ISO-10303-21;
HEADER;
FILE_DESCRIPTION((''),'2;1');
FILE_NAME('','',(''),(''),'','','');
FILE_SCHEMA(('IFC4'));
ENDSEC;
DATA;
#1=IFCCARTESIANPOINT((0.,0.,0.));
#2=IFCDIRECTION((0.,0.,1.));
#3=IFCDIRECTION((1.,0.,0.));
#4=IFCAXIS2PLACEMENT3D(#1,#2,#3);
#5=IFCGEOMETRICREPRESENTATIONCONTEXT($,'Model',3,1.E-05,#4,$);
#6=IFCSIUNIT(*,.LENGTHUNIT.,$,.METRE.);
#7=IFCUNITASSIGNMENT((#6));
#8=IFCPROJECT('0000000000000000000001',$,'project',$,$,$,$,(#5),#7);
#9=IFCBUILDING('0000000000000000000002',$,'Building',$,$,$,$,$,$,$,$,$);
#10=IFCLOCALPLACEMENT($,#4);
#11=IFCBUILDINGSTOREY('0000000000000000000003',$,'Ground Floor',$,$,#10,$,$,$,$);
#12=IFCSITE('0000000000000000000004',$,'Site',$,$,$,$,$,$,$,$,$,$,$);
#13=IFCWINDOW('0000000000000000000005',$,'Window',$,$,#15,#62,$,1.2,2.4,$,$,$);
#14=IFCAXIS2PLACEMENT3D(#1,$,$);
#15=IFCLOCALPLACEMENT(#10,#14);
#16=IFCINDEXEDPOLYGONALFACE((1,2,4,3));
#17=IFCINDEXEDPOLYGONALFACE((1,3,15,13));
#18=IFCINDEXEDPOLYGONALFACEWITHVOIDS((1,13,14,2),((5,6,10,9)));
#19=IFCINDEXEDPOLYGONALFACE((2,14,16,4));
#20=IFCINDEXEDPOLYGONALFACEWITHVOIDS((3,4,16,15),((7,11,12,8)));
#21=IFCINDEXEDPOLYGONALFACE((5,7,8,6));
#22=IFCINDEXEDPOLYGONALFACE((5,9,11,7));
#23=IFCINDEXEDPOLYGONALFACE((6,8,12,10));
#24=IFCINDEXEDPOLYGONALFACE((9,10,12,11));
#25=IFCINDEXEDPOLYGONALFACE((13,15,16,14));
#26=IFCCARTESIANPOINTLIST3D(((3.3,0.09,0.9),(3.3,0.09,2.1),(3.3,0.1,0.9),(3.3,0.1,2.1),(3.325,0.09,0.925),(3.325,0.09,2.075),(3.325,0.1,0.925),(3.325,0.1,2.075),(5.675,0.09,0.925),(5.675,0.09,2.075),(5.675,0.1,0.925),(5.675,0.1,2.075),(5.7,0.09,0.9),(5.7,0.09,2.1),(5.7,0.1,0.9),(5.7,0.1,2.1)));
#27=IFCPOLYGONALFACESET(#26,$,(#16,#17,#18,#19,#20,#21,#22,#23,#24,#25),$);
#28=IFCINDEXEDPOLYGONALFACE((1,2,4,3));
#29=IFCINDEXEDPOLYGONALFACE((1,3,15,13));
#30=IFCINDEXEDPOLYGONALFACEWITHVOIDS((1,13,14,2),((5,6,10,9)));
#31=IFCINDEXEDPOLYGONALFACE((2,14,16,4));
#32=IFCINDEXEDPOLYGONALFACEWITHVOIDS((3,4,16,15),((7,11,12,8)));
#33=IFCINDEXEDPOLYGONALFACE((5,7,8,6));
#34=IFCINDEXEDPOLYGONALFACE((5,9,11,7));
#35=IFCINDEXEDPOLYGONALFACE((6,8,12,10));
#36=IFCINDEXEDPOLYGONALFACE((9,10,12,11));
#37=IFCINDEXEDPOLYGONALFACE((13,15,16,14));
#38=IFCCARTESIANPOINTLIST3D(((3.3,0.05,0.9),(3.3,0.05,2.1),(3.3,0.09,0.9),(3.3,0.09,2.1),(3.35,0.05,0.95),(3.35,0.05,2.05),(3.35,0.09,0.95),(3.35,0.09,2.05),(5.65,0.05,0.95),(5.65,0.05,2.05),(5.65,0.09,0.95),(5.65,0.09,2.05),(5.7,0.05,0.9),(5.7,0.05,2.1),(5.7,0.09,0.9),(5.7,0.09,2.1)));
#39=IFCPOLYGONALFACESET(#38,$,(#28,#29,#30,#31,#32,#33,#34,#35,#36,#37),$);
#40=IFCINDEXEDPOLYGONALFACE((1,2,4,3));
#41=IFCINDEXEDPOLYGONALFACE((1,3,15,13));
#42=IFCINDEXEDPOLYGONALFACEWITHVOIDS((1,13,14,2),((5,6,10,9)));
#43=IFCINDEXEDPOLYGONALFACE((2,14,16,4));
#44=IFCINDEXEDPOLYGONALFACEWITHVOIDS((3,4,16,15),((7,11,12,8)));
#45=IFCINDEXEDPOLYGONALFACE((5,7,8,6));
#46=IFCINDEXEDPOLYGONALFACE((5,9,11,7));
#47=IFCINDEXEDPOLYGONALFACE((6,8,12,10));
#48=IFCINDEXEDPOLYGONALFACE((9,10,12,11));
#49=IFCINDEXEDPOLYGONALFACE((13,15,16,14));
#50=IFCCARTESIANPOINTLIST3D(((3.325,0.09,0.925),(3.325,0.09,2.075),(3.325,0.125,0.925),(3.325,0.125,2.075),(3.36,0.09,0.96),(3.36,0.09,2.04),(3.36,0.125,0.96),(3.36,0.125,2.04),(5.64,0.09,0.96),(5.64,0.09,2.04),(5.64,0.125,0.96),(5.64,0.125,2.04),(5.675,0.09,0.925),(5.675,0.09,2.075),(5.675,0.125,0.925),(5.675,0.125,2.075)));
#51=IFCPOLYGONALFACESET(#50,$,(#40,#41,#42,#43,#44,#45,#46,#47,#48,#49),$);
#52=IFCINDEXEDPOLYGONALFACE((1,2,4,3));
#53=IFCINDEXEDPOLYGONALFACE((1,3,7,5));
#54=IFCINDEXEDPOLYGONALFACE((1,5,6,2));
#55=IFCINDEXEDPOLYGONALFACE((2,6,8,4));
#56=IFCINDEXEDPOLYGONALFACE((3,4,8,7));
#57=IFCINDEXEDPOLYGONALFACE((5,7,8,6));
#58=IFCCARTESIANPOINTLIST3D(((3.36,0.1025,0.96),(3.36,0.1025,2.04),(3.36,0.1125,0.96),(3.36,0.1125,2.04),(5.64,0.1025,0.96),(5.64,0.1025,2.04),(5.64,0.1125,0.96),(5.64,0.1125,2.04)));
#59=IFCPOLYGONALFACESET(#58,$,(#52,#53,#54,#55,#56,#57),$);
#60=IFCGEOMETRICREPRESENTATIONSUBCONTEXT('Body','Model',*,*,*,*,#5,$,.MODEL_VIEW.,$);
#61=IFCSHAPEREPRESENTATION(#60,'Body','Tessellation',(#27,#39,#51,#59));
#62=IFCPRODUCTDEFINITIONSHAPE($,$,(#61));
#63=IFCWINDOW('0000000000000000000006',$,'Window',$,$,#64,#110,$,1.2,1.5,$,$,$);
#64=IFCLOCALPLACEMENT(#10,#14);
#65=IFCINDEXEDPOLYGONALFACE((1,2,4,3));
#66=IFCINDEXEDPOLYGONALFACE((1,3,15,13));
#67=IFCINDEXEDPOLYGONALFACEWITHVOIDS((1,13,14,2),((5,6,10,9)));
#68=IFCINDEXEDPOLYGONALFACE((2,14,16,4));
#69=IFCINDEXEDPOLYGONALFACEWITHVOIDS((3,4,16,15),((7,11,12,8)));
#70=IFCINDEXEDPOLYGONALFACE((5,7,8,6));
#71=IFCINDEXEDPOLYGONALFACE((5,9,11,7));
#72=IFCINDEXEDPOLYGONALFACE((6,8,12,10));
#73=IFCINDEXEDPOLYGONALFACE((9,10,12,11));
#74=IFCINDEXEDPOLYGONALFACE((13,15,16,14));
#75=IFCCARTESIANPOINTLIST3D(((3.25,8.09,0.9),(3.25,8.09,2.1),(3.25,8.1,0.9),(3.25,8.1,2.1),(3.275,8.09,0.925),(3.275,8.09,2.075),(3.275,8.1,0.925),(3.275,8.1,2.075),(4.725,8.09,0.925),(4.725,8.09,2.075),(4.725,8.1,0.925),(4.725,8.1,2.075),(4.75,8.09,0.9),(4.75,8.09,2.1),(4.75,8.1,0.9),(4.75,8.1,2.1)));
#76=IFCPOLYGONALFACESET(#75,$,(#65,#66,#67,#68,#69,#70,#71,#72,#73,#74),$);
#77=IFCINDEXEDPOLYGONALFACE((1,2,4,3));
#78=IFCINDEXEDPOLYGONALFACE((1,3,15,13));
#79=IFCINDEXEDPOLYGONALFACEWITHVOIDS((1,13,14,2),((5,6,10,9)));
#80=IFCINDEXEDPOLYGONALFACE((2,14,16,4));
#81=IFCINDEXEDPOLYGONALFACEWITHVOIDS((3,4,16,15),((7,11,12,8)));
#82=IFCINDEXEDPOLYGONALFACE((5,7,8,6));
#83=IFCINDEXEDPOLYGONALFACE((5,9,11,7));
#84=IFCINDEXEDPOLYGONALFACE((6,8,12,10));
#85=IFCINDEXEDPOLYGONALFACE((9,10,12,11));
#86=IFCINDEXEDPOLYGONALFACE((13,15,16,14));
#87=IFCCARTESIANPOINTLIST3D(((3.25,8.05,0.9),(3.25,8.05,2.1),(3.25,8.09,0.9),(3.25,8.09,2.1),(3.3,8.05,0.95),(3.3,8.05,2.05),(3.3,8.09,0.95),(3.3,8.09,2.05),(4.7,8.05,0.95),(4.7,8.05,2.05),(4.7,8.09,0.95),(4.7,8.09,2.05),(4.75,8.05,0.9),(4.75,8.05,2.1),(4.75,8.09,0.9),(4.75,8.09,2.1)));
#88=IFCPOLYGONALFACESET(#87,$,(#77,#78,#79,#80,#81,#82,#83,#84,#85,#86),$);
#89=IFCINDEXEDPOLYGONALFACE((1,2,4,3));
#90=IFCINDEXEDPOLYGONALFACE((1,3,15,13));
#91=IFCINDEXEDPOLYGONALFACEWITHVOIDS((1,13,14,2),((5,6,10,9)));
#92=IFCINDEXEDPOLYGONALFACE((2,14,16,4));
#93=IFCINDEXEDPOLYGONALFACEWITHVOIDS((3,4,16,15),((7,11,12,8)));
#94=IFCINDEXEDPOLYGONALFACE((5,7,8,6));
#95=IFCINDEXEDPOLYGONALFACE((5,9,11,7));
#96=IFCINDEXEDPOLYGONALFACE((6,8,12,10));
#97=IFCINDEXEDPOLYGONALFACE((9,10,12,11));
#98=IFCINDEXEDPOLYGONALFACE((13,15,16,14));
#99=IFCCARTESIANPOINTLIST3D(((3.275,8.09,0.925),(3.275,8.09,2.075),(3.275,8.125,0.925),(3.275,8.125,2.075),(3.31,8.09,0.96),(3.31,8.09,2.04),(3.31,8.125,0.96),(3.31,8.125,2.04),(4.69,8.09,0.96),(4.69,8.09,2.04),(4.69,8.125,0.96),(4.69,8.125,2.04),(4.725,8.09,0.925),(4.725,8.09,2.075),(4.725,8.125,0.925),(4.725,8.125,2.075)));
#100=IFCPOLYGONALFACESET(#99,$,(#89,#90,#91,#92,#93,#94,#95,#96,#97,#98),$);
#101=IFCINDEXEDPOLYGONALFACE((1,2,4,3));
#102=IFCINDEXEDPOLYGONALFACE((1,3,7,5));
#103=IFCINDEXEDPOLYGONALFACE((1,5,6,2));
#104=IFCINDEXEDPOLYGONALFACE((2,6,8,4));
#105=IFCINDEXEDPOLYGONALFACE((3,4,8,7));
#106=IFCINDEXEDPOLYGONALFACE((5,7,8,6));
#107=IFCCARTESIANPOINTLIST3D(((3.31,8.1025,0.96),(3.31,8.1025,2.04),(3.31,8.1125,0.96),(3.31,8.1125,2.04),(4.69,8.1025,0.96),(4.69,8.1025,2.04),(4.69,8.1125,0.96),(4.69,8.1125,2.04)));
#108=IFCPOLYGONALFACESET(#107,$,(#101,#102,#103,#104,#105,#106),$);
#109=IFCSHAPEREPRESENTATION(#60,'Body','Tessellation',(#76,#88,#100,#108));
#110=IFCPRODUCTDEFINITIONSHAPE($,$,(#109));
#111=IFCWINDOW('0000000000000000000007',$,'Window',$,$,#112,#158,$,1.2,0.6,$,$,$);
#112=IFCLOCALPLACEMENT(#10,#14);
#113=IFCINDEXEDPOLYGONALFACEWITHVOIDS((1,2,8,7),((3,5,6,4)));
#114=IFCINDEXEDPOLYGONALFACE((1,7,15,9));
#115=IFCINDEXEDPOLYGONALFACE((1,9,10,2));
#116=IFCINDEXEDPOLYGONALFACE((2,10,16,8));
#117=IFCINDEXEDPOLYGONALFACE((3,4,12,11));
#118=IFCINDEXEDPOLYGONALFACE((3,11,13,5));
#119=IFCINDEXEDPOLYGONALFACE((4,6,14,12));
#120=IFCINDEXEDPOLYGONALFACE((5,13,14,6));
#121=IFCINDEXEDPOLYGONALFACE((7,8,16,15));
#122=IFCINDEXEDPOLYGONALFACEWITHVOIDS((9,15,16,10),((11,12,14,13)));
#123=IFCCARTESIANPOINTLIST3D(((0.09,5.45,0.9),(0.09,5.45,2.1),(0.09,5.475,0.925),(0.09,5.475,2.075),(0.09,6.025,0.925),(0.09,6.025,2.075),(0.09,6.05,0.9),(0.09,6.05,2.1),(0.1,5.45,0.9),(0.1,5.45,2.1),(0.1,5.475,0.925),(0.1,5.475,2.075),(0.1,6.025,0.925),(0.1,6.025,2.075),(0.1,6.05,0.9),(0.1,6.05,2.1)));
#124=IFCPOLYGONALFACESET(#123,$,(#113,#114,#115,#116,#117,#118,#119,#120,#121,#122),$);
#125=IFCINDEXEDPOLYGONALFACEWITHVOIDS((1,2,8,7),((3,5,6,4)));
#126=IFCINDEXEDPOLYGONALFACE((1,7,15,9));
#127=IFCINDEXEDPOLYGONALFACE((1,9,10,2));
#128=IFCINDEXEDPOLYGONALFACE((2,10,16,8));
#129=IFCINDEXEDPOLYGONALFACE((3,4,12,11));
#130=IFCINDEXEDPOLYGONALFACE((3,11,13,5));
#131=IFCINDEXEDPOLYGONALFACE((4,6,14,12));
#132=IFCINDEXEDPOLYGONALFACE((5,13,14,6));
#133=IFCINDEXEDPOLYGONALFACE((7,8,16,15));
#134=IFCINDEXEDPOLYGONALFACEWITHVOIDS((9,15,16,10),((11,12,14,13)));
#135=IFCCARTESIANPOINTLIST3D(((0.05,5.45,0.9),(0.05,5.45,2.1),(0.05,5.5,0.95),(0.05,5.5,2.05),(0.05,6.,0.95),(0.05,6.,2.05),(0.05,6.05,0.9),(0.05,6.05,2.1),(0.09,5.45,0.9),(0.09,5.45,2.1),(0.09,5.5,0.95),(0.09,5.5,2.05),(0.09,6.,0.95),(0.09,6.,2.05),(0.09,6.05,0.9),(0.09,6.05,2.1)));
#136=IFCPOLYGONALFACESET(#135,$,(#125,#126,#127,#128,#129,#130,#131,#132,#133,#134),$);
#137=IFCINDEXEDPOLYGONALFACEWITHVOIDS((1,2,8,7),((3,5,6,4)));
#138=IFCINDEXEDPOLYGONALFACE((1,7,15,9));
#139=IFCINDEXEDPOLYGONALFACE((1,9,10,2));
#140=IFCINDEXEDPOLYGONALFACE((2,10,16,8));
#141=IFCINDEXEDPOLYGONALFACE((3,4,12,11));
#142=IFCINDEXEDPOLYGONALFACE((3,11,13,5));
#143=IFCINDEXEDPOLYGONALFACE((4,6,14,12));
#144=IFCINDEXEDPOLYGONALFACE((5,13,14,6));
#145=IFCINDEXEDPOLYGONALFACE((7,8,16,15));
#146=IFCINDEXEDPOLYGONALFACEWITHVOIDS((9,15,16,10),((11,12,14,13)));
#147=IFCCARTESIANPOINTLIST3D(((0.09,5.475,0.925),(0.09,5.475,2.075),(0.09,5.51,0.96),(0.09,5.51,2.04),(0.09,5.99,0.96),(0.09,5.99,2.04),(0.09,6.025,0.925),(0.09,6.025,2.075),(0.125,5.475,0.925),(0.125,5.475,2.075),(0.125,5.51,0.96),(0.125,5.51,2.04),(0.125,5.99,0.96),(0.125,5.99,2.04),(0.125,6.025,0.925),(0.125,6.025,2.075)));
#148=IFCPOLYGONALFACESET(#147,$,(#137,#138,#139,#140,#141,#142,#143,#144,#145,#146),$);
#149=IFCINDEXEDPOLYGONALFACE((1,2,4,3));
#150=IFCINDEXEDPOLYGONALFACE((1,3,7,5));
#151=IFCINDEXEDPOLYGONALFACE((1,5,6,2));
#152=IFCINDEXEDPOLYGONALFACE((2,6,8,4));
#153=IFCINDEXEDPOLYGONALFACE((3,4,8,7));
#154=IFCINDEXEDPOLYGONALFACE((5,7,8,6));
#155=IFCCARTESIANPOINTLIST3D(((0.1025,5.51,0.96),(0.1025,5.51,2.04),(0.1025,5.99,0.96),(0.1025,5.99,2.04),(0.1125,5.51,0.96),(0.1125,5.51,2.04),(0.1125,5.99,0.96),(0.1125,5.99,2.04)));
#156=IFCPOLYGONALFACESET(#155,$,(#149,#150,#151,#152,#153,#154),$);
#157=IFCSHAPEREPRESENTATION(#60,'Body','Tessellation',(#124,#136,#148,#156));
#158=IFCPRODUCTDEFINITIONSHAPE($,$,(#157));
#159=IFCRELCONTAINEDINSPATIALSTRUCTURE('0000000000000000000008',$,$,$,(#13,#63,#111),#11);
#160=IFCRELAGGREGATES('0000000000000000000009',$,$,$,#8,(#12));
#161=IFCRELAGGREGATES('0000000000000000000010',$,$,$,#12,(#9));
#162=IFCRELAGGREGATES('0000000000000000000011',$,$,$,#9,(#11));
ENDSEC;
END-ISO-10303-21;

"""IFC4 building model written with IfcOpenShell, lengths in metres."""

from ifc_helpers import new_model, si_unit, frame, origin_with_axes, place, context, subcontext, project, spatial, line, indexed_curve, outline, extrude, element, save


model = new_model("IFC4")

# Units and contexts
model_context = context("Model", 3, precision=1e-05, world=origin_with_axes())
body_context = subcontext(model_context, "Body", "Model", "MODEL_VIEW")
ifc_project = project(units=[si_unit("LENGTHUNIT", "METRE")], contexts=[model_context])

# Site, building, storey
site = spatial("IfcSite", under=ifc_project, Name="Site")
building = spatial("IfcBuilding", under=site, Name="Building")
storey_placement = place(None, origin_with_axes())
storey = spatial("IfcBuildingStorey", under=building, at=storey_placement, Name="Ground Floor")

# Windows
window_1_placement = place(storey_placement, frame((3.3, 0.0, 0.9), z_axis=(0.0, 0.0, 1.0), x_axis=(1.0, 0.0, 0.0)))
element("IfcWindow", 1, at=window_1_placement, inside=storey, Name="Window", OverallHeight=1.2, OverallWidth=2.4, context=body_context, shape_type="SweptSolid", body=[
    extrude(outline(indexed_curve([(0.0, 0.0), (2.4, 0.0), (2.4, 1.2), (0.0, 1.2)], segments=[line(1, 2, 3, 4, 1)]), holes=[indexed_curve([(0.025, 0.025), (2.375, 0.025), (2.375, 1.175), (0.025, 1.175)], segments=[line(1, 2, 3, 4, 1)])]), frame((0.0, 0.09, 0.0), z_axis=(0.0, -1.0, 0.0), x_axis=(1.0, 0.0, 0.0)), (0.0, 0.0, -1.0), 0.01),
    extrude(outline(indexed_curve([(0.0, 0.0), (2.4, 0.0), (2.4, 1.2), (0.0, 1.2)], segments=[line(1, 2, 3, 4, 1)]), holes=[indexed_curve([(0.05, 0.05), (2.35, 0.05), (2.35, 1.15), (0.05, 1.15)], segments=[line(1, 2, 3, 4, 1)])]), frame((0.0, 0.05, 0.0), z_axis=(0.0, -1.0, 0.0), x_axis=(1.0, 0.0, 0.0)), (0.0, 0.0, -1.0), 0.04),
    extrude(outline(indexed_curve([(0.0, 0.0), (2.35, 0.0), (2.35, 1.15), (0.0, 1.15)], segments=[line(1, 2, 3, 4, 1)]), holes=[indexed_curve([(0.035, 0.035), (2.315, 0.035), (2.315, 1.115), (0.035, 1.115)], segments=[line(1, 2, 3, 4, 1)])]), frame((0.025, 0.09, 0.025), z_axis=(0.0, -1.0, 0.0), x_axis=(1.0, 0.0, 0.0)), (0.0, 0.0, -1.0), 0.035),
    extrude(outline(indexed_curve([(0.035, 0.035), (2.315, 0.035), (2.315, 1.115), (0.035, 1.115)], segments=[line(1, 2, 3, 4, 1)])), frame((0.025, 0.1025, 0.025), z_axis=(0.0, -1.0, 0.0), x_axis=(1.0, 0.0, 0.0)), (0.0, 0.0, -1.0), 0.01),
])
window_2_placement = place(storey_placement, frame((3.25, 8.0, 0.9), z_axis=(0.0, 0.0, 1.0), x_axis=(1.0, 0.0, 0.0)))
element("IfcWindow", 2, at=window_2_placement, inside=storey, Name="Window", OverallHeight=1.2, OverallWidth=1.5, context=body_context, shape_type="SweptSolid", body=[
    extrude(outline(indexed_curve([(0.0, 0.0), (1.5, 0.0), (1.5, 1.2), (0.0, 1.2)], segments=[line(1, 2, 3, 4, 1)]), holes=[indexed_curve([(0.025, 0.025), (1.475, 0.025), (1.475, 1.175), (0.025, 1.175)], segments=[line(1, 2, 3, 4, 1)])]), frame((0.0, 0.09, 0.0), z_axis=(0.0, -1.0, 0.0), x_axis=(1.0, 0.0, 0.0)), (0.0, 0.0, -1.0), 0.01),
    extrude(outline(indexed_curve([(0.0, 0.0), (1.5, 0.0), (1.5, 1.2), (0.0, 1.2)], segments=[line(1, 2, 3, 4, 1)]), holes=[indexed_curve([(0.05, 0.05), (1.45, 0.05), (1.45, 1.15), (0.05, 1.15)], segments=[line(1, 2, 3, 4, 1)])]), frame((0.0, 0.05, 0.0), z_axis=(0.0, -1.0, 0.0), x_axis=(1.0, 0.0, 0.0)), (0.0, 0.0, -1.0), 0.04),
    extrude(outline(indexed_curve([(0.0, 0.0), (1.45, 0.0), (1.45, 1.15), (0.0, 1.15)], segments=[line(1, 2, 3, 4, 1)]), holes=[indexed_curve([(0.035, 0.035), (1.415, 0.035), (1.415, 1.115), (0.035, 1.115)], segments=[line(1, 2, 3, 4, 1)])]), frame((0.025, 0.09, 0.025), z_axis=(0.0, -1.0, 0.0), x_axis=(1.0, 0.0, 0.0)), (0.0, 0.0, -1.0), 0.035),
    extrude(outline(indexed_curve([(0.035, 0.035), (1.415, 0.035), (1.415, 1.115), (0.035, 1.115)], segments=[line(1, 2, 3, 4, 1)])), frame((0.025, 0.1025, 0.025), z_axis=(0.0, -1.0, 0.0), x_axis=(1.0, 0.0, 0.0)), (0.0, 0.0, -1.0), 0.01),
])
window_3_placement = place(storey_placement, frame((0.0, 6.05, 0.9), z_axis=(0.0, 0.0, 1.0), x_axis=(0.0, -1.0, 0.0)))
element("IfcWindow", 3, at=window_3_placement, inside=storey, Name="Window", OverallHeight=1.2, OverallWidth=0.6, context=body_context, shape_type="SweptSolid", body=[
    extrude(outline(indexed_curve([(0.0, 0.0), (0.6, 0.0), (0.6, 1.2), (0.0, 1.2)], segments=[line(1, 2, 3, 4, 1)]), holes=[indexed_curve([(0.025, 0.025), (0.575, 0.025), (0.575, 1.175), (0.025, 1.175)], segments=[line(1, 2, 3, 4, 1)])]), frame((0.0, 0.09, 0.0), z_axis=(0.0, -1.0, 0.0), x_axis=(1.0, 0.0, 0.0)), (0.0, 0.0, -1.0), 0.01),
    extrude(outline(indexed_curve([(0.0, 0.0), (0.6, 0.0), (0.6, 1.2), (0.0, 1.2)], segments=[line(1, 2, 3, 4, 1)]), holes=[indexed_curve([(0.05, 0.05), (0.55, 0.05), (0.55, 1.15), (0.05, 1.15)], segments=[line(1, 2, 3, 4, 1)])]), frame((0.0, 0.05, 0.0), z_axis=(0.0, -1.0, 0.0), x_axis=(1.0, 0.0, 0.0)), (0.0, 0.0, -1.0), 0.04),
    extrude(outline(indexed_curve([(0.0, 0.0), (0.55, 0.0), (0.55, 1.15), (0.0, 1.15)], segments=[line(1, 2, 3, 4, 1)]), holes=[indexed_curve([(0.035, 0.035), (0.515, 0.035), (0.515, 1.115), (0.035, 1.115)], segments=[line(1, 2, 3, 4, 1)])]), frame((0.025, 0.09, 0.025), z_axis=(0.0, -1.0, 0.0), x_axis=(1.0, 0.0, 0.0)), (0.0, 0.0, -1.0), 0.035),
    extrude(outline(indexed_curve([(0.035, 0.035), (0.515, 0.035), (0.515, 1.115), (0.035, 1.115)], segments=[line(1, 2, 3, 4, 1)])), frame((0.025, 0.1025, 0.025), z_axis=(0.0, -1.0, 0.0), x_axis=(1.0, 0.0, 0.0)), (0.0, 0.0, -1.0), 0.01),
])

save(model, "model.ifc")
